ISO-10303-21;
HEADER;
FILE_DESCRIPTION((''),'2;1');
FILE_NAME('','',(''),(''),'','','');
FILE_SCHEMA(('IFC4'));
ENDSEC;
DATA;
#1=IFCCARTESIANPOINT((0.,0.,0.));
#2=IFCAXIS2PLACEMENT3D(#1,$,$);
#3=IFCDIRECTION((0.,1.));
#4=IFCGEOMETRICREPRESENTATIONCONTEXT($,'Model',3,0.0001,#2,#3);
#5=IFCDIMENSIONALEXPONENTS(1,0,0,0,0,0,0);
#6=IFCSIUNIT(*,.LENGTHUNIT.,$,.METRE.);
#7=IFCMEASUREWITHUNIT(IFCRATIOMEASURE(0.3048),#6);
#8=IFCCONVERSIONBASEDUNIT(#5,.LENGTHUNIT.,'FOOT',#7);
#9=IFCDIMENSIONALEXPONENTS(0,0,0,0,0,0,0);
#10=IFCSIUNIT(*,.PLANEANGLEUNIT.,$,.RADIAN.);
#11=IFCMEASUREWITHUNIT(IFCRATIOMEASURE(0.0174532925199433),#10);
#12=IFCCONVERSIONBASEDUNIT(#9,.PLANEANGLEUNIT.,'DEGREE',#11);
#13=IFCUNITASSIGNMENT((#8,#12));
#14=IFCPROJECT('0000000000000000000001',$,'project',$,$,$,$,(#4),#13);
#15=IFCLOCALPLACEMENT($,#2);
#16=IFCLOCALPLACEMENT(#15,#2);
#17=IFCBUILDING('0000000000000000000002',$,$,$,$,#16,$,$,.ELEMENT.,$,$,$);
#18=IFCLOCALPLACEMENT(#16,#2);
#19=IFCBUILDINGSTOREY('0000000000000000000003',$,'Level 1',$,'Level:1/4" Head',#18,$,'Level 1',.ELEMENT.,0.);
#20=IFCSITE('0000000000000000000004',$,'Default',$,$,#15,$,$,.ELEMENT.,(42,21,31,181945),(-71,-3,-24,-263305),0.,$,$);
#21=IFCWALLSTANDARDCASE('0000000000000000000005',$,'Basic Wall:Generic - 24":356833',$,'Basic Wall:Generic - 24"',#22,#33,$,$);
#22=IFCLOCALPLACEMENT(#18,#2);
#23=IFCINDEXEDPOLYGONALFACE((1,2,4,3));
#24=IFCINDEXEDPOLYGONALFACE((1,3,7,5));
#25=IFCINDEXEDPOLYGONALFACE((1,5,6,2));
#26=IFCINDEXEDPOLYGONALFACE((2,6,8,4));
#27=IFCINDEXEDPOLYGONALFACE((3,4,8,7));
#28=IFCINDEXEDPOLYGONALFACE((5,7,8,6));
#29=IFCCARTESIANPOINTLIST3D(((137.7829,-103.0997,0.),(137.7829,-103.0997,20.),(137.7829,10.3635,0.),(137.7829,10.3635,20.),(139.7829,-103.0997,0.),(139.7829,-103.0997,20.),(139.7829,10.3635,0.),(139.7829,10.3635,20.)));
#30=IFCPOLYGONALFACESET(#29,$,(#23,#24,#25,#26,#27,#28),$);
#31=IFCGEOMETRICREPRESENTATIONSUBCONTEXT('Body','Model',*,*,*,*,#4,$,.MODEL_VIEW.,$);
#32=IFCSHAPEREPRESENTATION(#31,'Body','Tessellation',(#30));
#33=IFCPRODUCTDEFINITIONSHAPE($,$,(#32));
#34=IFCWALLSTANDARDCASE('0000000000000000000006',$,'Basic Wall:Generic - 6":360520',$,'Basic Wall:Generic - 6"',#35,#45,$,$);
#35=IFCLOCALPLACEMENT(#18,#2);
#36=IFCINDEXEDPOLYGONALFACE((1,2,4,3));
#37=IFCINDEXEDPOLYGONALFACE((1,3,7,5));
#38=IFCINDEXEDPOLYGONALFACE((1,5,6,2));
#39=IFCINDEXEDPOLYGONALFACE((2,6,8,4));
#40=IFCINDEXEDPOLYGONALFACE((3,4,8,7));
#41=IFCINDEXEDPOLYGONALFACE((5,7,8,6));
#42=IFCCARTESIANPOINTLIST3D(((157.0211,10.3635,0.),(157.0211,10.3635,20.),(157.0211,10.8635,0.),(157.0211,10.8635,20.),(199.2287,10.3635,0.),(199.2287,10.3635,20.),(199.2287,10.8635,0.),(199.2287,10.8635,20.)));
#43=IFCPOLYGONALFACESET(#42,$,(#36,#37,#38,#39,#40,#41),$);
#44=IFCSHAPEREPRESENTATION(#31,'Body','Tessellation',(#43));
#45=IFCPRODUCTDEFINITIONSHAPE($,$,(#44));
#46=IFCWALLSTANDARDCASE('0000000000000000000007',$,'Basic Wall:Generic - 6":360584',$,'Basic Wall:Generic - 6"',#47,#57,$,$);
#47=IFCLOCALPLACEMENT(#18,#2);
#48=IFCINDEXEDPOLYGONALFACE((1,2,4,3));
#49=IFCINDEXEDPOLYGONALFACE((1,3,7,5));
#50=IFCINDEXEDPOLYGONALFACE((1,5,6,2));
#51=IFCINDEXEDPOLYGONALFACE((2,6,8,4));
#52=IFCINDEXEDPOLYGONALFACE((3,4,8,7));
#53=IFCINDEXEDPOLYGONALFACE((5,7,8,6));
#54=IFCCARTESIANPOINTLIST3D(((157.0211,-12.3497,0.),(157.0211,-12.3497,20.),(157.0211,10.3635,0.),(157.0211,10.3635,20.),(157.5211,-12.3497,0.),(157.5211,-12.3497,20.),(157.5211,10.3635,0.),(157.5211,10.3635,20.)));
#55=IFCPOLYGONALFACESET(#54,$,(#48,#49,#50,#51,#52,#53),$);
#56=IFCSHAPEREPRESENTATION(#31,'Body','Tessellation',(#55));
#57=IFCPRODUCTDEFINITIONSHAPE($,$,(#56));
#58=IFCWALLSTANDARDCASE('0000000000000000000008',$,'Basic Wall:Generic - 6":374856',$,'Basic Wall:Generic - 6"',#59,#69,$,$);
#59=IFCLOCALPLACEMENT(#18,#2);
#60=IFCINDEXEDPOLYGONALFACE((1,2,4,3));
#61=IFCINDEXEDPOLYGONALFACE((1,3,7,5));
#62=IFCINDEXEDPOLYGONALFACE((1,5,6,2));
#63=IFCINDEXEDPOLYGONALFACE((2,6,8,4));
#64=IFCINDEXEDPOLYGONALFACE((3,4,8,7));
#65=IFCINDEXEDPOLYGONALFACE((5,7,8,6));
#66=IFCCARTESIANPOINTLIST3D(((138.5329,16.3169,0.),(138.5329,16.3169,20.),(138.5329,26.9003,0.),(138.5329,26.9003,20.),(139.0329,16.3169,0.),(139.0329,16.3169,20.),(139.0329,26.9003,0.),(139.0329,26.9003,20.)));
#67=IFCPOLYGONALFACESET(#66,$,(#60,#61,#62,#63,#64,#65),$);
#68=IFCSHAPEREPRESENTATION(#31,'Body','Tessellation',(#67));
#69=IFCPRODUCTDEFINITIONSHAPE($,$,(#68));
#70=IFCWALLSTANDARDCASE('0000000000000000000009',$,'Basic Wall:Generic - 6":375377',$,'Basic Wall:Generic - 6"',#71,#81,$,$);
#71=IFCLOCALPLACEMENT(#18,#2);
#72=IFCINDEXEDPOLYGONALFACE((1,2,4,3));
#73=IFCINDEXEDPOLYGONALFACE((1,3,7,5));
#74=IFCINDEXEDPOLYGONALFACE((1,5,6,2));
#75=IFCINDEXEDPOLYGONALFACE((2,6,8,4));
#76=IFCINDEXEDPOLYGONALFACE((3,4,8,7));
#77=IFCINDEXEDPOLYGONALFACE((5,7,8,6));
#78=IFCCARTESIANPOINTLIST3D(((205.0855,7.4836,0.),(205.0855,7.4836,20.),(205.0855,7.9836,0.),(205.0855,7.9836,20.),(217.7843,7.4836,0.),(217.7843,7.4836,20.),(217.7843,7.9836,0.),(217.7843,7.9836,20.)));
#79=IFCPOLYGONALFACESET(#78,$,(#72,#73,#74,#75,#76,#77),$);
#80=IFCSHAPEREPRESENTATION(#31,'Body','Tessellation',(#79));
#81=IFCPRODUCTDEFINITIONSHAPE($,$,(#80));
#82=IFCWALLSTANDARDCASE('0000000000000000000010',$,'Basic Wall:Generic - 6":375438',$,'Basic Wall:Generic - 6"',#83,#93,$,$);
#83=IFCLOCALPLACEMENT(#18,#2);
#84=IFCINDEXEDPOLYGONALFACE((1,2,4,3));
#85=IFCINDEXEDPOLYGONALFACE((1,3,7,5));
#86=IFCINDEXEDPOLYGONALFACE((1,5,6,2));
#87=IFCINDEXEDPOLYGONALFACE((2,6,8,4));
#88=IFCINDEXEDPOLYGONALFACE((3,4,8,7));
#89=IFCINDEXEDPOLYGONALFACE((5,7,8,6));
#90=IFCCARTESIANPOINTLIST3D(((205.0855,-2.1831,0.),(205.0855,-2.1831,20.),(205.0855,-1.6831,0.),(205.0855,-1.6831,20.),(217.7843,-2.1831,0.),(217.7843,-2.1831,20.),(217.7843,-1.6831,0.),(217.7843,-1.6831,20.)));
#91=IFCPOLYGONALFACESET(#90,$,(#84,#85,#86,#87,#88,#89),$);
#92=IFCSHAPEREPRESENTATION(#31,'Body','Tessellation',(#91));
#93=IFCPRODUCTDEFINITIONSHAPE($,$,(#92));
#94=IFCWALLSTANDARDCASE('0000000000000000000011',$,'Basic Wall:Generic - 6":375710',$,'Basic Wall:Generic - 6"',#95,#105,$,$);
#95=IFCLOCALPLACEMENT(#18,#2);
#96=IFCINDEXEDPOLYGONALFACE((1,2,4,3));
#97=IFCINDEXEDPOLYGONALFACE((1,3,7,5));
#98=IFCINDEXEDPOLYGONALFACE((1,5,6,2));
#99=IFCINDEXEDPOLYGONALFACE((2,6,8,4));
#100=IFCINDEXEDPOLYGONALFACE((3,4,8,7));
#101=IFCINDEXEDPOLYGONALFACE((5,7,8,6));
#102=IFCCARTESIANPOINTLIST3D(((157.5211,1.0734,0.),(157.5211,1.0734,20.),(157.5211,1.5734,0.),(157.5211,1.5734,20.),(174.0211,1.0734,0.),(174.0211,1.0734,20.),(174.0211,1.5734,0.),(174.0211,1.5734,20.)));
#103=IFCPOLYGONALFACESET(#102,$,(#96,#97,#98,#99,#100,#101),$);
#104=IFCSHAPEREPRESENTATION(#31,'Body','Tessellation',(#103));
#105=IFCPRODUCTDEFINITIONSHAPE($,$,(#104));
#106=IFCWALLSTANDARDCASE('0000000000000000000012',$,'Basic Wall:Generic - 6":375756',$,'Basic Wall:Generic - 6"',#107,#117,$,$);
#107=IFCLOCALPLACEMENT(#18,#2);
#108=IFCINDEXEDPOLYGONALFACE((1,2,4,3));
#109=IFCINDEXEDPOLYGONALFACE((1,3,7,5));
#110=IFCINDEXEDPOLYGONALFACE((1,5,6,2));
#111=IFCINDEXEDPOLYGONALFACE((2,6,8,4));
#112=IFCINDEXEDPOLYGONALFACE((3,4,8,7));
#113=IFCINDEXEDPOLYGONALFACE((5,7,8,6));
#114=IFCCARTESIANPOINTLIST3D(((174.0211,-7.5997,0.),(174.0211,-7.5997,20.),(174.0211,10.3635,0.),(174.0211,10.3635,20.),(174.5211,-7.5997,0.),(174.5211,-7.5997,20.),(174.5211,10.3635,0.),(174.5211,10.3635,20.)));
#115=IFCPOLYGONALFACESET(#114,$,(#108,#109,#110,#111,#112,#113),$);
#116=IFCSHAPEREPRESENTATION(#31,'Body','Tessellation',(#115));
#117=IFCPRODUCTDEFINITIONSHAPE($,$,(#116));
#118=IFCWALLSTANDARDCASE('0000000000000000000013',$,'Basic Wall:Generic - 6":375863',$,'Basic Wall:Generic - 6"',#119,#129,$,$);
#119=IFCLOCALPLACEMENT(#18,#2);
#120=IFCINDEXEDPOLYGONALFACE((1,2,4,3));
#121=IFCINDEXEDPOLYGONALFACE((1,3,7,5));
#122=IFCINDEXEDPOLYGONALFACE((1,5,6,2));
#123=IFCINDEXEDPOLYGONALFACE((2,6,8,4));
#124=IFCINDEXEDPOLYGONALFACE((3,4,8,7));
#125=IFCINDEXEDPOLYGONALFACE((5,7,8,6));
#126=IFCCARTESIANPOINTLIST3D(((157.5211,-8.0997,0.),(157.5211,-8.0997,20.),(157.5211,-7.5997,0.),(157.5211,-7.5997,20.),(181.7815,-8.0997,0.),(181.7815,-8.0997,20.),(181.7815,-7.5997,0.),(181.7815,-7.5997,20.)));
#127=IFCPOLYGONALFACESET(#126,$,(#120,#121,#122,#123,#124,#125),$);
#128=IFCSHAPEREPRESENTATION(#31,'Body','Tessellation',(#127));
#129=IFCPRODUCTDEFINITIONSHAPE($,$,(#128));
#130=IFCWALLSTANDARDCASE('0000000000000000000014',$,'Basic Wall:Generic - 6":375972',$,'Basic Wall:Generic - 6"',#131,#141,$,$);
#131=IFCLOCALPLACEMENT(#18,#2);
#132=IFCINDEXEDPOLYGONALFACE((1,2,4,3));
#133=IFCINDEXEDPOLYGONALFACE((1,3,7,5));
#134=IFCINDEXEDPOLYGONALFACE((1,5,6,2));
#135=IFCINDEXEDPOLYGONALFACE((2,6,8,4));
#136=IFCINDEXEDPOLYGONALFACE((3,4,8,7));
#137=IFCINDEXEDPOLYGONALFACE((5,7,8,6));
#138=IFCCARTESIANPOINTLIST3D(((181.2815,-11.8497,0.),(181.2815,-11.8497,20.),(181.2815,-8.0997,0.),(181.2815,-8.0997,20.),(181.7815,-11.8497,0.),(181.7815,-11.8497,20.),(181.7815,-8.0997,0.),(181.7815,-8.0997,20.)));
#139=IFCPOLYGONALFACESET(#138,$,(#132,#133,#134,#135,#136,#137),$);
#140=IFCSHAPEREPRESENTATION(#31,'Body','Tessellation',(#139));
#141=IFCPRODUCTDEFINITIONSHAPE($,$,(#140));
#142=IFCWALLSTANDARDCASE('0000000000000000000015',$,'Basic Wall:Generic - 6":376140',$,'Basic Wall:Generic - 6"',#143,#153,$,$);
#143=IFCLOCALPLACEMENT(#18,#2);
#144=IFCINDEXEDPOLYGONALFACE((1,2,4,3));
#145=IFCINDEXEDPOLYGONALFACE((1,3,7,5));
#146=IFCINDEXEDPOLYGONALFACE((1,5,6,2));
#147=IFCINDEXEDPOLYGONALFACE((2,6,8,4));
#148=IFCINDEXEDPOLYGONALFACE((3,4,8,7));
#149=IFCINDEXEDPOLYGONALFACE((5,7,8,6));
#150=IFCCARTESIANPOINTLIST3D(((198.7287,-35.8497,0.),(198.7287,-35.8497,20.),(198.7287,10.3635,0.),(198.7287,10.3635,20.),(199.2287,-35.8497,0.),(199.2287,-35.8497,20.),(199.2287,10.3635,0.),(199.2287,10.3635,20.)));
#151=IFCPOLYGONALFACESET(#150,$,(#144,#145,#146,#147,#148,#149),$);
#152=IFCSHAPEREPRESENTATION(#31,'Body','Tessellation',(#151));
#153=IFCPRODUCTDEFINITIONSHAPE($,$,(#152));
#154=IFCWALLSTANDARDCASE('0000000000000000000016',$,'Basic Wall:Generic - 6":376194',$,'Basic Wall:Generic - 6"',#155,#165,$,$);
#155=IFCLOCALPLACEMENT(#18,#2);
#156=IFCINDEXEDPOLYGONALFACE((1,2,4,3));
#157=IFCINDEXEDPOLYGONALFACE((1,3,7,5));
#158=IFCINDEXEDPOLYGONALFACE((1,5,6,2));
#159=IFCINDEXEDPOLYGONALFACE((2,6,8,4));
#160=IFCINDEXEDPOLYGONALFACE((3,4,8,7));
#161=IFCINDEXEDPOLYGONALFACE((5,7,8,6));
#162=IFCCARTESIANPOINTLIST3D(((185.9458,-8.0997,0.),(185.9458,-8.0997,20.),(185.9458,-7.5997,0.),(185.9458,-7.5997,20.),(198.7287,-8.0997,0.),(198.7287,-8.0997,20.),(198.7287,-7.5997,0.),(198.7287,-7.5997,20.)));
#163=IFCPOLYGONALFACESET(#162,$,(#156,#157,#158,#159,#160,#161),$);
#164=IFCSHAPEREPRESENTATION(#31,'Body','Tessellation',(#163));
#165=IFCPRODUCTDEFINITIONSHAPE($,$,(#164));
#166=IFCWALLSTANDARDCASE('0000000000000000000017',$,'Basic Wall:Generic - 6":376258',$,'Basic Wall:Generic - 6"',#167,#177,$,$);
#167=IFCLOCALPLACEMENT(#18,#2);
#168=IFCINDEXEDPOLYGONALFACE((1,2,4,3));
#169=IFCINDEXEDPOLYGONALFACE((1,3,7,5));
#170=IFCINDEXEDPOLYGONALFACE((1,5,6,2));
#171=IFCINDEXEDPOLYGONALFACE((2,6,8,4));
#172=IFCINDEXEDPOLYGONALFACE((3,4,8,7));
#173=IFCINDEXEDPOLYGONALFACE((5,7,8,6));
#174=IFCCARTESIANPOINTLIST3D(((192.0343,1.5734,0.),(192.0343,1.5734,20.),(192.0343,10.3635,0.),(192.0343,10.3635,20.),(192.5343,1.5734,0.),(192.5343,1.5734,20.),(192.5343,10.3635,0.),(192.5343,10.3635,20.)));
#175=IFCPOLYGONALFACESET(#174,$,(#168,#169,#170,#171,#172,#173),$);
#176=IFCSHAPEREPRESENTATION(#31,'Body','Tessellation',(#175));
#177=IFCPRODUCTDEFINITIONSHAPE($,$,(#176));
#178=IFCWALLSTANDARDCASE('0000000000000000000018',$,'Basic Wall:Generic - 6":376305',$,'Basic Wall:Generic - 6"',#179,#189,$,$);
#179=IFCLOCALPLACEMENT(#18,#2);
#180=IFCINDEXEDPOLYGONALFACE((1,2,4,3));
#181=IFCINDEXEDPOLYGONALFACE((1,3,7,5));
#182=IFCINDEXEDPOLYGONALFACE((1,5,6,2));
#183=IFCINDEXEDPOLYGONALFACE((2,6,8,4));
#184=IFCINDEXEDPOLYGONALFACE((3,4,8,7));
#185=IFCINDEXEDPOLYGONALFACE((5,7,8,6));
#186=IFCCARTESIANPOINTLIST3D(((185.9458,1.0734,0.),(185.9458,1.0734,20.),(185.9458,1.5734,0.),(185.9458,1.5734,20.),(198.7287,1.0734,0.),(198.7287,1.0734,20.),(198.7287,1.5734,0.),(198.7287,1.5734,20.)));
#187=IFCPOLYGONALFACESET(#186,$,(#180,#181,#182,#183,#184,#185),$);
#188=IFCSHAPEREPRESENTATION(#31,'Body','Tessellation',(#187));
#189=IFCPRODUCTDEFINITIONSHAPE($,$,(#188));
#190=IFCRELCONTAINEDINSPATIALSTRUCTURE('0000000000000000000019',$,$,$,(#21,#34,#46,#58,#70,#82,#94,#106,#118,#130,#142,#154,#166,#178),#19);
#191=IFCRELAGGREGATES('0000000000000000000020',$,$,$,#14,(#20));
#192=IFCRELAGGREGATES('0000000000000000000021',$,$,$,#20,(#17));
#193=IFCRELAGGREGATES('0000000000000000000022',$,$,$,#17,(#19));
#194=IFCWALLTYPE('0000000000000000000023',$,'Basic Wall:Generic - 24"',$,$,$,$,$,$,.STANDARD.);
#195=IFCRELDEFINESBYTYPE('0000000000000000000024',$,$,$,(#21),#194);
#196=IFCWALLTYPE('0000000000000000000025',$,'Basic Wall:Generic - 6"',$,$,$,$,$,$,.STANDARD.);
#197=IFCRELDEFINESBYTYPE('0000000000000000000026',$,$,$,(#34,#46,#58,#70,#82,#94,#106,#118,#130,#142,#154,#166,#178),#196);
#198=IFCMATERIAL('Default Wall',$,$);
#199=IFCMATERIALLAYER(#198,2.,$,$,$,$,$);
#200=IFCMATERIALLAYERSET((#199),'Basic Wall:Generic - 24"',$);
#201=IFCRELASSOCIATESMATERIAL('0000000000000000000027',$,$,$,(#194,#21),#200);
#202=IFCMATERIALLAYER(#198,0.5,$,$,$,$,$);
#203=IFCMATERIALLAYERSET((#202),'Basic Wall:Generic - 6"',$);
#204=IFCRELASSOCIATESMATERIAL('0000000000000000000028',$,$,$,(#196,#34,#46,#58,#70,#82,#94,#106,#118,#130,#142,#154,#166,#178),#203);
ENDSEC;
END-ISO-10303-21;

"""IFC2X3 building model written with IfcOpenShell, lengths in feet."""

from ifc_helpers import new_model, entity, si_unit, converted_unit, direction, frame, frame_2d, origin, place, context, subcontext, project, spatial, rectangle, extrude, material, layer, layer_set, layer_usage, type_object, element, save


model = new_model("IFC2X3")

# Units and contexts
model_context = context("Model", 3, precision=0.0001, world=origin(), true_north=direction((0.0, 1.0)))
body_context = subcontext(model_context, "Body", "Model", "MODEL_VIEW")
ifc_project = project(units=[converted_unit("LENGTHUNIT", "FOOT", entity("IfcRatioMeasure", 0.3048), si_unit("LENGTHUNIT", "METRE"), dimensions=[1, 0, 0, 0, 0, 0, 0]), converted_unit("PLANEANGLEUNIT", "DEGREE", entity("IfcRatioMeasure", 0.0174532925199433), si_unit("PLANEANGLEUNIT", "RADIAN"), dimensions=[0, 0, 0, 0, 0, 0, 0])], contexts=[model_context])

# Site, building, storey
site_placement = place(None, origin())
site = spatial("IfcSite", under=ifc_project, at=site_placement, Name="Default", CompositionType="ELEMENT", RefLatitude=(42, 21, 31, 181945), RefLongitude=(-71, -3, -24, -263305), RefElevation=0.0)
building_placement = place(site_placement, origin())
building = spatial("IfcBuilding", under=site, at=building_placement, CompositionType="ELEMENT")
storey_placement = place(building_placement, origin())
storey = spatial("IfcBuildingStorey", under=building, at=storey_placement, Name="Level 1", ObjectType="Level:1/4\" Head", LongName="Level 1", CompositionType="ELEMENT", Elevation=0.0)

# Walls
ifc_material = material(Name="Default Wall")
ifc_layer_1 = layer(ifc_material, 2.0)
ifc_layer_set_1 = layer_set([ifc_layer_1], Name="Basic Wall:Generic - 24\"")
ifc_layer_usage_1 = layer_usage(ifc_layer_set_1, "AXIS2", "NEGATIVE", 1.0)
wall_type_1 = type_object("IfcWallType", Name="Basic Wall:Generic - 24\"", PredefinedType="STANDARD", material=ifc_layer_set_1)
wall_1_placement = place(storey_placement, frame((138.7829, 10.3635, 0.0), z_axis=(0.0, 0.0, 1.0), x_axis=(0.0, -1.0, 0.0)))
element("IfcWallStandardCase", 1, at=wall_1_placement, inside=storey, type_object=wall_type_1, material=ifc_layer_usage_1, Name="Basic Wall:Generic - 24\":356833", ObjectType="Basic Wall:Generic - 24\"", context=body_context, shape_type="SweptSolid", body=[
    extrude(rectangle(XDim=113.4633, YDim=2.0, at=frame_2d((56.7316, 0.0), x_axis=(-1.0, 0.0))), origin(), (0.0, 0.0, 1.0), 20.0),
])
ifc_layer_2 = layer(ifc_material, 0.5)
ifc_layer_set_2 = layer_set([ifc_layer_2], Name="Basic Wall:Generic - 6\"")
ifc_layer_usage_2 = layer_usage(ifc_layer_set_2, "AXIS2", "NEGATIVE", 0.25)
wall_type_2 = type_object("IfcWallType", Name="Basic Wall:Generic - 6\"", PredefinedType="STANDARD", material=ifc_layer_set_2)
wall_2_placement = place(storey_placement, frame((199.2287, 10.6135, 0.0), z_axis=(0.0, 0.0, 1.0), x_axis=(-1.0, 0.0, 0.0)))
element("IfcWallStandardCase", 2, at=wall_2_placement, inside=storey, type_object=wall_type_2, material=ifc_layer_usage_2, Name="Basic Wall:Generic - 6\":360520", ObjectType="Basic Wall:Generic - 6\"", context=body_context, shape_type="SweptSolid", body=[
    extrude(rectangle(XDim=42.2076, YDim=0.5, at=frame_2d((21.1038, 0.0), x_axis=(-1.0, 0.0))), origin(), (0.0, 0.0, 1.0), 20.0),
])
ifc_layer_usage_3 = layer_usage(ifc_layer_set_2, "AXIS2", "NEGATIVE", 0.25)
wall_3_placement = place(storey_placement, frame((157.2711, 10.3635, 0.0), z_axis=(0.0, 0.0, 1.0), x_axis=(0.0, -1.0, 0.0)))
element("IfcWallStandardCase", 3, at=wall_3_placement, inside=storey, type_object=wall_type_2, material=ifc_layer_usage_3, Name="Basic Wall:Generic - 6\":360584", ObjectType="Basic Wall:Generic - 6\"", context=body_context, shape_type="SweptSolid", body=[
    extrude(rectangle(XDim=22.7133, YDim=0.5, at=frame_2d((11.3566, 0.0), x_axis=(-1.0, 0.0))), origin(), (0.0, 0.0, 1.0), 20.0),
])
ifc_layer_usage_4 = layer_usage(ifc_layer_set_2, "AXIS2", "NEGATIVE", 0.25)
wall_4_placement = place(storey_placement, frame((138.7829, 16.3169, 0.0), z_axis=(0.0, 0.0, 1.0), x_axis=(0.0, 1.0, 0.0)))
element("IfcWallStandardCase", 4, at=wall_4_placement, inside=storey, type_object=wall_type_2, material=ifc_layer_usage_4, Name="Basic Wall:Generic - 6\":374856", ObjectType="Basic Wall:Generic - 6\"", context=body_context, shape_type="SweptSolid", body=[
    extrude(rectangle(XDim=10.5833, YDim=0.5, at=frame_2d((5.2917, 0.0), x_axis=(-1.0, 0.0))), origin(), (0.0, 0.0, 1.0), 20.0),
])
ifc_layer_usage_5 = layer_usage(ifc_layer_set_2, "AXIS2", "NEGATIVE", 0.25)
wall_5_placement = place(storey_placement, frame((217.7843, 7.7336, 0.0), z_axis=(0.0, 0.0, 1.0), x_axis=(-1.0, 0.0, 0.0)))
element("IfcWallStandardCase", 5, at=wall_5_placement, inside=storey, type_object=wall_type_2, material=ifc_layer_usage_5, Name="Basic Wall:Generic - 6\":375377", ObjectType="Basic Wall:Generic - 6\"", context=body_context, shape_type="SweptSolid", body=[
    extrude(rectangle(XDim=12.6987, YDim=0.5, at=frame_2d((6.3494, 0.0), x_axis=(-1.0, 0.0))), origin(), (0.0, 0.0, 1.0), 20.0),
])
ifc_layer_usage_6 = layer_usage(ifc_layer_set_2, "AXIS2", "NEGATIVE", 0.25)
wall_6_placement = place(storey_placement, frame((217.7843, -1.9331, 0.0), z_axis=(0.0, 0.0, 1.0), x_axis=(-1.0, 0.0, 0.0)))
element("IfcWallStandardCase", 6, at=wall_6_placement, inside=storey, type_object=wall_type_2, material=ifc_layer_usage_6, Name="Basic Wall:Generic - 6\":375438", ObjectType="Basic Wall:Generic - 6\"", context=body_context, shape_type="SweptSolid", body=[
    extrude(rectangle(XDim=12.6987, YDim=0.5, at=frame_2d((6.3494, 0.0), x_axis=(-1.0, 0.0))), origin(), (0.0, 0.0, 1.0), 20.0),
])
ifc_layer_usage_7 = layer_usage(ifc_layer_set_2, "AXIS2", "NEGATIVE", 0.25)
wall_7_placement = place(storey_placement, frame((157.5211, 1.3234, 0.0)))
element("IfcWallStandardCase", 7, at=wall_7_placement, inside=storey, type_object=wall_type_2, material=ifc_layer_usage_7, Name="Basic Wall:Generic - 6\":375710", ObjectType="Basic Wall:Generic - 6\"", context=body_context, shape_type="SweptSolid", body=[
    extrude(rectangle(XDim=16.5, YDim=0.5, at=frame_2d((8.25, 0.0), x_axis=(-1.0, 0.0))), origin(), (0.0, 0.0, 1.0), 20.0),
])
ifc_layer_usage_8 = layer_usage(ifc_layer_set_2, "AXIS2", "NEGATIVE", 0.25)
wall_8_placement = place(storey_placement, frame((174.2711, -7.5997, 0.0), z_axis=(0.0, 0.0, 1.0), x_axis=(0.0, 1.0, 0.0)))
element("IfcWallStandardCase", 8, at=wall_8_placement, inside=storey, type_object=wall_type_2, material=ifc_layer_usage_8, Name="Basic Wall:Generic - 6\":375756", ObjectType="Basic Wall:Generic - 6\"", context=body_context, shape_type="SweptSolid", body=[
    extrude(rectangle(XDim=17.9633, YDim=0.5, at=frame_2d((8.9816, 0.0), x_axis=(-1.0, 0.0))), origin(), (0.0, 0.0, 1.0), 20.0),
])
ifc_layer_usage_9 = layer_usage(ifc_layer_set_2, "AXIS2", "NEGATIVE", 0.25)
wall_9_placement = place(storey_placement, frame((181.7815, -7.8497, 0.0), z_axis=(0.0, 0.0, 1.0), x_axis=(-1.0, 0.0, 0.0)))
element("IfcWallStandardCase", 9, at=wall_9_placement, inside=storey, type_object=wall_type_2, material=ifc_layer_usage_9, Name="Basic Wall:Generic - 6\":375863", ObjectType="Basic Wall:Generic - 6\"", context=body_context, shape_type="SweptSolid", body=[
    extrude(rectangle(XDim=24.2604, YDim=0.5, at=frame_2d((12.1302, 0.0), x_axis=(-1.0, 0.0))), origin(), (0.0, 0.0, 1.0), 20.0),
])
ifc_layer_usage_10 = layer_usage(ifc_layer_set_2, "AXIS2", "NEGATIVE", 0.25)
wall_10_placement = place(storey_placement, frame((181.5315, -8.0997, 0.0), z_axis=(0.0, 0.0, 1.0), x_axis=(0.0, -1.0, 0.0)))
element("IfcWallStandardCase", 10, at=wall_10_placement, inside=storey, type_object=wall_type_2, material=ifc_layer_usage_10, Name="Basic Wall:Generic - 6\":375972", ObjectType="Basic Wall:Generic - 6\"", context=body_context, shape_type="SweptSolid", body=[
    extrude(rectangle(XDim=3.75, YDim=0.5, at=frame_2d((1.875, 0.0), x_axis=(-1.0, 0.0))), origin(), (0.0, 0.0, 1.0), 20.0),
])
ifc_layer_usage_11 = layer_usage(ifc_layer_set_2, "AXIS2", "NEGATIVE", 0.25)
wall_11_placement = place(storey_placement, frame((198.9787, 10.3635, 0.0), z_axis=(0.0, 0.0, 1.0), x_axis=(0.0, -1.0, 0.0)))
element("IfcWallStandardCase", 11, at=wall_11_placement, inside=storey, type_object=wall_type_2, material=ifc_layer_usage_11, Name="Basic Wall:Generic - 6\":376140", ObjectType="Basic Wall:Generic - 6\"", context=body_context, shape_type="SweptSolid", body=[
    extrude(rectangle(XDim=46.2133, YDim=0.5, at=frame_2d((23.1066, 0.0), x_axis=(-1.0, 0.0))), origin(), (0.0, 0.0, 1.0), 20.0),
])
ifc_layer_usage_12 = layer_usage(ifc_layer_set_2, "AXIS2", "NEGATIVE", 0.25)
wall_12_placement = place(storey_placement, frame((198.7287, -7.8497, 0.0), z_axis=(0.0, 0.0, 1.0), x_axis=(-1.0, 0.0, 0.0)))
element("IfcWallStandardCase", 12, at=wall_12_placement, inside=storey, type_object=wall_type_2, material=ifc_layer_usage_12, Name="Basic Wall:Generic - 6\":376194", ObjectType="Basic Wall:Generic - 6\"", context=body_context, shape_type="SweptSolid", body=[
    extrude(rectangle(XDim=12.7829, YDim=0.5, at=frame_2d((6.3914, 0.0), x_axis=(-1.0, 0.0))), origin(), (0.0, 0.0, 1.0), 20.0),
])
ifc_layer_usage_13 = layer_usage(ifc_layer_set_2, "AXIS2", "NEGATIVE", 0.25)
wall_13_placement = place(storey_placement, frame((192.2843, 10.3635, 0.0), z_axis=(0.0, 0.0, 1.0), x_axis=(0.0, -1.0, 0.0)))
element("IfcWallStandardCase", 13, at=wall_13_placement, inside=storey, type_object=wall_type_2, material=ifc_layer_usage_13, Name="Basic Wall:Generic - 6\":376258", ObjectType="Basic Wall:Generic - 6\"", context=body_context, shape_type="SweptSolid", body=[
    extrude(rectangle(XDim=8.7901, YDim=0.5, at=frame_2d((4.3951, 0.0), x_axis=(-1.0, 0.0))), origin(), (0.0, 0.0, 1.0), 20.0),
])
ifc_layer_usage_14 = layer_usage(ifc_layer_set_2, "AXIS2", "NEGATIVE", 0.25)
wall_14_placement = place(storey_placement, frame((198.7287, 1.3234, 0.0), z_axis=(0.0, 0.0, 1.0), x_axis=(-1.0, 0.0, 0.0)))
element("IfcWallStandardCase", 14, at=wall_14_placement, inside=storey, type_object=wall_type_2, material=ifc_layer_usage_14, Name="Basic Wall:Generic - 6\":376305", ObjectType="Basic Wall:Generic - 6\"", context=body_context, shape_type="SweptSolid", body=[
    extrude(rectangle(XDim=12.7829, YDim=0.5, at=frame_2d((6.3914, 0.0), x_axis=(-1.0, 0.0))), origin(), (0.0, 0.0, 1.0), 20.0),
])

save(model, "model.ifc")
